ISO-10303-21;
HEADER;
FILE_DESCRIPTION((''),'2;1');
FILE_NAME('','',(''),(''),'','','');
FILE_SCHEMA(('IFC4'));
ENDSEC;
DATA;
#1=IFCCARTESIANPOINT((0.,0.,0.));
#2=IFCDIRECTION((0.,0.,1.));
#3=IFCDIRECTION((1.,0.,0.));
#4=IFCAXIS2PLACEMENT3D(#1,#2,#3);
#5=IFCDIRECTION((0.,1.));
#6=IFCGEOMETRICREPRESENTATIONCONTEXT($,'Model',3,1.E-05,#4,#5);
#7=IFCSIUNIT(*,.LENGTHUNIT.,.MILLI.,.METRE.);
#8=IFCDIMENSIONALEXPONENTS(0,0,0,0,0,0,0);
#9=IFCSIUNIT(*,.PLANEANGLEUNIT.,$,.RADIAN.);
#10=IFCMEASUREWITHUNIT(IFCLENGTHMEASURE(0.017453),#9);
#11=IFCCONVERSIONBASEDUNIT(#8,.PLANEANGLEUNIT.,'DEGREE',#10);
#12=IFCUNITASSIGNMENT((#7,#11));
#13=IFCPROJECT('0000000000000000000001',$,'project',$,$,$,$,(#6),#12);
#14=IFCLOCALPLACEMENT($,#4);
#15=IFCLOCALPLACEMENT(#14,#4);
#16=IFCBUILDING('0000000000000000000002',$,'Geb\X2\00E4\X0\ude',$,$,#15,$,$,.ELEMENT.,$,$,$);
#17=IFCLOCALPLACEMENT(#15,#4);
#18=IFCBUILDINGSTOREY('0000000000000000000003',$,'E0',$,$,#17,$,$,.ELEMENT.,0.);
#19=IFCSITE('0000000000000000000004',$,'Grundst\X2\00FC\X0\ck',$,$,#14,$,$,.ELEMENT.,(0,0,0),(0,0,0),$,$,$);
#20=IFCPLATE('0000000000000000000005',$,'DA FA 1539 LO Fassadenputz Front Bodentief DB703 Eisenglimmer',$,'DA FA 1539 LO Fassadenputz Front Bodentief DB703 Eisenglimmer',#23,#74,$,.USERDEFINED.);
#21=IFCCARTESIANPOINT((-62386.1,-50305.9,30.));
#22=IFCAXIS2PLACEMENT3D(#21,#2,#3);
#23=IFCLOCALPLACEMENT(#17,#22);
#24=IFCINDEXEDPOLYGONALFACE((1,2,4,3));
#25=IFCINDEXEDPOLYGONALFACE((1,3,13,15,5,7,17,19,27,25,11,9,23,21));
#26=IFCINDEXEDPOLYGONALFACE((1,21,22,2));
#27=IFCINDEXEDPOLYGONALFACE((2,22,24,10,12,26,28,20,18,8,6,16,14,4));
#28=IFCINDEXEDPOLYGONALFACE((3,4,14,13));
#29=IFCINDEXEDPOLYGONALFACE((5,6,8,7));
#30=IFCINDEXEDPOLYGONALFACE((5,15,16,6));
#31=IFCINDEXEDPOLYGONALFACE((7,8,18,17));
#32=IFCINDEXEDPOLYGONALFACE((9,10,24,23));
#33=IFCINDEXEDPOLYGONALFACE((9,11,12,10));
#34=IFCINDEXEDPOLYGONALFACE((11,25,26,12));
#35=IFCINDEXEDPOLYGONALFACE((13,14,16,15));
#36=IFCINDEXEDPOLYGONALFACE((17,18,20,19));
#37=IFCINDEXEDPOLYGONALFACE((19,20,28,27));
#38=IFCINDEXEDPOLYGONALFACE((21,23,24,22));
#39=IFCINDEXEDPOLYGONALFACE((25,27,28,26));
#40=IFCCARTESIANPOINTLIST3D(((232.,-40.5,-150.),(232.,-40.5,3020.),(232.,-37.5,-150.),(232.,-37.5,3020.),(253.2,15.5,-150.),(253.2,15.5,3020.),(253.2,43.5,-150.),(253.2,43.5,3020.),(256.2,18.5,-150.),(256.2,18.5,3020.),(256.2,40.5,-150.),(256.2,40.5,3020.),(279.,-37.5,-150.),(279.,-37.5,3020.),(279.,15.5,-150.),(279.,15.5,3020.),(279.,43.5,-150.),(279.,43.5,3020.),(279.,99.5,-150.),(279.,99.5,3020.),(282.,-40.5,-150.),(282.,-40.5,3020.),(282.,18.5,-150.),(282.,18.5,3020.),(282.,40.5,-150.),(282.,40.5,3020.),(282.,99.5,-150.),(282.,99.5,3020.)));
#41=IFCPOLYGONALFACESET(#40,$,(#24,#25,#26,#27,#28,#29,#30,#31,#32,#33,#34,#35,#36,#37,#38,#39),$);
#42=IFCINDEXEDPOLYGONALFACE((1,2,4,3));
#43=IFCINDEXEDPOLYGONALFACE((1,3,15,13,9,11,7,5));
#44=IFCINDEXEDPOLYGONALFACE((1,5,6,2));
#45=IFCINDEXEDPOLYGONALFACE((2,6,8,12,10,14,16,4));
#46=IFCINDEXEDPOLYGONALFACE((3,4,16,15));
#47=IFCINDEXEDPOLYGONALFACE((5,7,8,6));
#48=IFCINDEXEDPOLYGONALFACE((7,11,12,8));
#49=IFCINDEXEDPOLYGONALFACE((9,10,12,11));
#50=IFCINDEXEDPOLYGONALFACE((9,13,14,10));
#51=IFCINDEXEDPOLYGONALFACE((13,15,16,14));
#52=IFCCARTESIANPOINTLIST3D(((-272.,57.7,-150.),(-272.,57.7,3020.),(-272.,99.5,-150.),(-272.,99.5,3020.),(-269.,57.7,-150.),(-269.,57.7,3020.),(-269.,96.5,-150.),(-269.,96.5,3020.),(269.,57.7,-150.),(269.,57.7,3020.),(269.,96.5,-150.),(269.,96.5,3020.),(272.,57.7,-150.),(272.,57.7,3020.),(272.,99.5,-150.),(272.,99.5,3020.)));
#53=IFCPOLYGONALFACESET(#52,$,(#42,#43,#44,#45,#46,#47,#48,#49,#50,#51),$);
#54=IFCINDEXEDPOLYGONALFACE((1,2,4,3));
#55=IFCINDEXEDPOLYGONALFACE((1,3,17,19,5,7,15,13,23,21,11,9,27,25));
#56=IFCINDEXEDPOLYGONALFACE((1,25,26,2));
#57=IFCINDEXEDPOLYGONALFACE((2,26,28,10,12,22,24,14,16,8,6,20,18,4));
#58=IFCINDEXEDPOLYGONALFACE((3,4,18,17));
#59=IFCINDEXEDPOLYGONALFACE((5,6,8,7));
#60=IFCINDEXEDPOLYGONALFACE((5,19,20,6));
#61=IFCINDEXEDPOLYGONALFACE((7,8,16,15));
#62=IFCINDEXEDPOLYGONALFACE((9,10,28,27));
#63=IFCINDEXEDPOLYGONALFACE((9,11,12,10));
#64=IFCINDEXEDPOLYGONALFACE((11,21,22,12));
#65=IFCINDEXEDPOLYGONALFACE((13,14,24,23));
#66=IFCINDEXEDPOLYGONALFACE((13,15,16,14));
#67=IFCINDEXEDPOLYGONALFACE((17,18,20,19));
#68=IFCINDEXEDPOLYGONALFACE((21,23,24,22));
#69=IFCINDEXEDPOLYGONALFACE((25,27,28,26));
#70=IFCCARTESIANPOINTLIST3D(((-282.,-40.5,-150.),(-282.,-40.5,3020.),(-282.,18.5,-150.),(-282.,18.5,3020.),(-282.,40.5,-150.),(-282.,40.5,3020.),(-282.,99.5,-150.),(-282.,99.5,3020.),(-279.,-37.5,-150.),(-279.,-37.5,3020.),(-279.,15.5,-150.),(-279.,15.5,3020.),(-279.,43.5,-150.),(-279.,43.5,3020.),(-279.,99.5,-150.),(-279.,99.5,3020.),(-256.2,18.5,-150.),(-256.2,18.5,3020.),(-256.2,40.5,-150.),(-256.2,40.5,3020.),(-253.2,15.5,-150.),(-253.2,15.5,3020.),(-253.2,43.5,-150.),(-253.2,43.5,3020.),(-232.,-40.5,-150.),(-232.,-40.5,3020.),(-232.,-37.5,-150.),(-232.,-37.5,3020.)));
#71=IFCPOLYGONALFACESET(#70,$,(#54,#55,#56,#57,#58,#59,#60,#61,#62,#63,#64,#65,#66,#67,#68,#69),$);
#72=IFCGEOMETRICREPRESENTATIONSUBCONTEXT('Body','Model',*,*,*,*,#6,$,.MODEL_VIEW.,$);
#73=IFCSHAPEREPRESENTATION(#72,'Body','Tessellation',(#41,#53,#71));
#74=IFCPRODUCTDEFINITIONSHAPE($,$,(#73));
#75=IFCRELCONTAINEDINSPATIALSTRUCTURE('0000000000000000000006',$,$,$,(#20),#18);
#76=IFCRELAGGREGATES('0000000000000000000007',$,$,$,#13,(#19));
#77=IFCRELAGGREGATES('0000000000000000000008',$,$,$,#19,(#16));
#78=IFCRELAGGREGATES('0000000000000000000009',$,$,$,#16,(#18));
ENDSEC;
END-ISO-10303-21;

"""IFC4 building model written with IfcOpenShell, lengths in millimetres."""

from ifc_helpers import new_model, entity, si_unit, converted_unit, direction, frame, origin_with_axes, place, context, subcontext, project, spatial, line, indexed_curve, outline, extrude, element, save


model = new_model("IFC4")

# Units and contexts
model_context = context("Model", 3, precision=1e-05, world=origin_with_axes(), true_north=direction((0.0, 1.0)))
body_context = subcontext(model_context, "Body", "Model", "MODEL_VIEW")
ifc_project = project(units=[si_unit("LENGTHUNIT", "METRE", prefix="MILLI"), converted_unit("PLANEANGLEUNIT", "DEGREE", entity("IfcLengthMeasure", 0.017453), si_unit("PLANEANGLEUNIT", "RADIAN"), dimensions=[0, 0, 0, 0, 0, 0, 0])], contexts=[model_context])

# Site, building, storey
site_placement = place(None, origin_with_axes())
site = spatial("IfcSite", under=ifc_project, at=site_placement, Name="Grundstück", CompositionType="ELEMENT", RefLatitude=(0, 0, 0), RefLongitude=(0, 0, 0))
building_placement = place(site_placement, origin_with_axes())
building = spatial("IfcBuilding", under=site, at=building_placement, Name="Gebäude", CompositionType="ELEMENT")
storey_placement = place(building_placement, origin_with_axes())
storey = spatial("IfcBuildingStorey", under=building, at=storey_placement, Name="E0", CompositionType="ELEMENT", Elevation=0.0)

# Plate
plate_1_placement = place(storey_placement, frame((-62386.1, -50305.9, 30.0), z_axis=(0.0, 0.0, 1.0), x_axis=(1.0, 0.0, 0.0)))
element("IfcPlate", 1, at=plate_1_placement, inside=storey, Name="DA FA 1539 LO Fassadenputz Front Bodentief DB703 Eisenglimmer", ObjectType="DA FA 1539 LO Fassadenputz Front Bodentief DB703 Eisenglimmer", PredefinedType="USERDEFINED", context=body_context, shape_type="SweptSolid", body=[
    extrude(outline(indexed_curve([(282.0, 99.5), (282.0, 40.5), (256.2, 40.5), (256.2, 18.5), (282.0, 18.5), (282.0, -40.5), (232.0, -40.5), (232.0, -37.5), (279.0, -37.5), (279.0, 15.5), (253.2, 15.5), (253.2, 43.5), (279.0, 43.5), (279.0, 99.5)], segments=[line(1, 2), line(2, 3), line(3, 4), line(4, 5), line(5, 6), line(6, 7), line(7, 8), line(8, 9), line(9, 10), line(10, 11), line(11, 12), line(12, 13), line(13, 14), line(14, 1)])), frame((0.0, 0.0, -150.0), z_axis=(0.0, 0.0, 1.0), x_axis=(1.0, 0.0, 0.0)), (0.0, 0.0, 1.0), 3170.0),
    extrude(outline(indexed_curve([(272.0, 99.5), (272.0, 57.7), (269.0, 57.7), (269.0, 96.5), (-269.0, 96.5), (-269.0, 57.7), (-272.0, 57.7), (-272.0, 99.5)], segments=[line(1, 2), line(2, 3), line(3, 4), line(4, 5), line(5, 6), line(6, 7), line(7, 8), line(8, 1)])), frame((0.0, 0.0, -150.0), z_axis=(0.0, 0.0, 1.0), x_axis=(1.0, 0.0, 0.0)), (0.0, 0.0, 1.0), 3170.0),
    extrude(outline(indexed_curve([(-282.0, 99.5), (-282.0, 40.5), (-256.2, 40.5), (-256.2, 18.5), (-282.0, 18.5), (-282.0, -40.5), (-232.0, -40.5), (-232.0, -37.5), (-279.0, -37.5), (-279.0, 15.5), (-253.2, 15.5), (-253.2, 43.5), (-279.0, 43.5), (-279.0, 99.5)], segments=[line(1, 2), line(2, 3), line(3, 4), line(4, 5), line(5, 6), line(6, 7), line(7, 8), line(8, 9), line(9, 10), line(10, 11), line(11, 12), line(12, 13), line(13, 14), line(14, 1)])), frame((0.0, 0.0, -150.0), z_axis=(0.0, 0.0, 1.0), x_axis=(1.0, 0.0, 0.0)), (0.0, 0.0, 1.0), 3170.0),
])

save(model, "model.ifc")
